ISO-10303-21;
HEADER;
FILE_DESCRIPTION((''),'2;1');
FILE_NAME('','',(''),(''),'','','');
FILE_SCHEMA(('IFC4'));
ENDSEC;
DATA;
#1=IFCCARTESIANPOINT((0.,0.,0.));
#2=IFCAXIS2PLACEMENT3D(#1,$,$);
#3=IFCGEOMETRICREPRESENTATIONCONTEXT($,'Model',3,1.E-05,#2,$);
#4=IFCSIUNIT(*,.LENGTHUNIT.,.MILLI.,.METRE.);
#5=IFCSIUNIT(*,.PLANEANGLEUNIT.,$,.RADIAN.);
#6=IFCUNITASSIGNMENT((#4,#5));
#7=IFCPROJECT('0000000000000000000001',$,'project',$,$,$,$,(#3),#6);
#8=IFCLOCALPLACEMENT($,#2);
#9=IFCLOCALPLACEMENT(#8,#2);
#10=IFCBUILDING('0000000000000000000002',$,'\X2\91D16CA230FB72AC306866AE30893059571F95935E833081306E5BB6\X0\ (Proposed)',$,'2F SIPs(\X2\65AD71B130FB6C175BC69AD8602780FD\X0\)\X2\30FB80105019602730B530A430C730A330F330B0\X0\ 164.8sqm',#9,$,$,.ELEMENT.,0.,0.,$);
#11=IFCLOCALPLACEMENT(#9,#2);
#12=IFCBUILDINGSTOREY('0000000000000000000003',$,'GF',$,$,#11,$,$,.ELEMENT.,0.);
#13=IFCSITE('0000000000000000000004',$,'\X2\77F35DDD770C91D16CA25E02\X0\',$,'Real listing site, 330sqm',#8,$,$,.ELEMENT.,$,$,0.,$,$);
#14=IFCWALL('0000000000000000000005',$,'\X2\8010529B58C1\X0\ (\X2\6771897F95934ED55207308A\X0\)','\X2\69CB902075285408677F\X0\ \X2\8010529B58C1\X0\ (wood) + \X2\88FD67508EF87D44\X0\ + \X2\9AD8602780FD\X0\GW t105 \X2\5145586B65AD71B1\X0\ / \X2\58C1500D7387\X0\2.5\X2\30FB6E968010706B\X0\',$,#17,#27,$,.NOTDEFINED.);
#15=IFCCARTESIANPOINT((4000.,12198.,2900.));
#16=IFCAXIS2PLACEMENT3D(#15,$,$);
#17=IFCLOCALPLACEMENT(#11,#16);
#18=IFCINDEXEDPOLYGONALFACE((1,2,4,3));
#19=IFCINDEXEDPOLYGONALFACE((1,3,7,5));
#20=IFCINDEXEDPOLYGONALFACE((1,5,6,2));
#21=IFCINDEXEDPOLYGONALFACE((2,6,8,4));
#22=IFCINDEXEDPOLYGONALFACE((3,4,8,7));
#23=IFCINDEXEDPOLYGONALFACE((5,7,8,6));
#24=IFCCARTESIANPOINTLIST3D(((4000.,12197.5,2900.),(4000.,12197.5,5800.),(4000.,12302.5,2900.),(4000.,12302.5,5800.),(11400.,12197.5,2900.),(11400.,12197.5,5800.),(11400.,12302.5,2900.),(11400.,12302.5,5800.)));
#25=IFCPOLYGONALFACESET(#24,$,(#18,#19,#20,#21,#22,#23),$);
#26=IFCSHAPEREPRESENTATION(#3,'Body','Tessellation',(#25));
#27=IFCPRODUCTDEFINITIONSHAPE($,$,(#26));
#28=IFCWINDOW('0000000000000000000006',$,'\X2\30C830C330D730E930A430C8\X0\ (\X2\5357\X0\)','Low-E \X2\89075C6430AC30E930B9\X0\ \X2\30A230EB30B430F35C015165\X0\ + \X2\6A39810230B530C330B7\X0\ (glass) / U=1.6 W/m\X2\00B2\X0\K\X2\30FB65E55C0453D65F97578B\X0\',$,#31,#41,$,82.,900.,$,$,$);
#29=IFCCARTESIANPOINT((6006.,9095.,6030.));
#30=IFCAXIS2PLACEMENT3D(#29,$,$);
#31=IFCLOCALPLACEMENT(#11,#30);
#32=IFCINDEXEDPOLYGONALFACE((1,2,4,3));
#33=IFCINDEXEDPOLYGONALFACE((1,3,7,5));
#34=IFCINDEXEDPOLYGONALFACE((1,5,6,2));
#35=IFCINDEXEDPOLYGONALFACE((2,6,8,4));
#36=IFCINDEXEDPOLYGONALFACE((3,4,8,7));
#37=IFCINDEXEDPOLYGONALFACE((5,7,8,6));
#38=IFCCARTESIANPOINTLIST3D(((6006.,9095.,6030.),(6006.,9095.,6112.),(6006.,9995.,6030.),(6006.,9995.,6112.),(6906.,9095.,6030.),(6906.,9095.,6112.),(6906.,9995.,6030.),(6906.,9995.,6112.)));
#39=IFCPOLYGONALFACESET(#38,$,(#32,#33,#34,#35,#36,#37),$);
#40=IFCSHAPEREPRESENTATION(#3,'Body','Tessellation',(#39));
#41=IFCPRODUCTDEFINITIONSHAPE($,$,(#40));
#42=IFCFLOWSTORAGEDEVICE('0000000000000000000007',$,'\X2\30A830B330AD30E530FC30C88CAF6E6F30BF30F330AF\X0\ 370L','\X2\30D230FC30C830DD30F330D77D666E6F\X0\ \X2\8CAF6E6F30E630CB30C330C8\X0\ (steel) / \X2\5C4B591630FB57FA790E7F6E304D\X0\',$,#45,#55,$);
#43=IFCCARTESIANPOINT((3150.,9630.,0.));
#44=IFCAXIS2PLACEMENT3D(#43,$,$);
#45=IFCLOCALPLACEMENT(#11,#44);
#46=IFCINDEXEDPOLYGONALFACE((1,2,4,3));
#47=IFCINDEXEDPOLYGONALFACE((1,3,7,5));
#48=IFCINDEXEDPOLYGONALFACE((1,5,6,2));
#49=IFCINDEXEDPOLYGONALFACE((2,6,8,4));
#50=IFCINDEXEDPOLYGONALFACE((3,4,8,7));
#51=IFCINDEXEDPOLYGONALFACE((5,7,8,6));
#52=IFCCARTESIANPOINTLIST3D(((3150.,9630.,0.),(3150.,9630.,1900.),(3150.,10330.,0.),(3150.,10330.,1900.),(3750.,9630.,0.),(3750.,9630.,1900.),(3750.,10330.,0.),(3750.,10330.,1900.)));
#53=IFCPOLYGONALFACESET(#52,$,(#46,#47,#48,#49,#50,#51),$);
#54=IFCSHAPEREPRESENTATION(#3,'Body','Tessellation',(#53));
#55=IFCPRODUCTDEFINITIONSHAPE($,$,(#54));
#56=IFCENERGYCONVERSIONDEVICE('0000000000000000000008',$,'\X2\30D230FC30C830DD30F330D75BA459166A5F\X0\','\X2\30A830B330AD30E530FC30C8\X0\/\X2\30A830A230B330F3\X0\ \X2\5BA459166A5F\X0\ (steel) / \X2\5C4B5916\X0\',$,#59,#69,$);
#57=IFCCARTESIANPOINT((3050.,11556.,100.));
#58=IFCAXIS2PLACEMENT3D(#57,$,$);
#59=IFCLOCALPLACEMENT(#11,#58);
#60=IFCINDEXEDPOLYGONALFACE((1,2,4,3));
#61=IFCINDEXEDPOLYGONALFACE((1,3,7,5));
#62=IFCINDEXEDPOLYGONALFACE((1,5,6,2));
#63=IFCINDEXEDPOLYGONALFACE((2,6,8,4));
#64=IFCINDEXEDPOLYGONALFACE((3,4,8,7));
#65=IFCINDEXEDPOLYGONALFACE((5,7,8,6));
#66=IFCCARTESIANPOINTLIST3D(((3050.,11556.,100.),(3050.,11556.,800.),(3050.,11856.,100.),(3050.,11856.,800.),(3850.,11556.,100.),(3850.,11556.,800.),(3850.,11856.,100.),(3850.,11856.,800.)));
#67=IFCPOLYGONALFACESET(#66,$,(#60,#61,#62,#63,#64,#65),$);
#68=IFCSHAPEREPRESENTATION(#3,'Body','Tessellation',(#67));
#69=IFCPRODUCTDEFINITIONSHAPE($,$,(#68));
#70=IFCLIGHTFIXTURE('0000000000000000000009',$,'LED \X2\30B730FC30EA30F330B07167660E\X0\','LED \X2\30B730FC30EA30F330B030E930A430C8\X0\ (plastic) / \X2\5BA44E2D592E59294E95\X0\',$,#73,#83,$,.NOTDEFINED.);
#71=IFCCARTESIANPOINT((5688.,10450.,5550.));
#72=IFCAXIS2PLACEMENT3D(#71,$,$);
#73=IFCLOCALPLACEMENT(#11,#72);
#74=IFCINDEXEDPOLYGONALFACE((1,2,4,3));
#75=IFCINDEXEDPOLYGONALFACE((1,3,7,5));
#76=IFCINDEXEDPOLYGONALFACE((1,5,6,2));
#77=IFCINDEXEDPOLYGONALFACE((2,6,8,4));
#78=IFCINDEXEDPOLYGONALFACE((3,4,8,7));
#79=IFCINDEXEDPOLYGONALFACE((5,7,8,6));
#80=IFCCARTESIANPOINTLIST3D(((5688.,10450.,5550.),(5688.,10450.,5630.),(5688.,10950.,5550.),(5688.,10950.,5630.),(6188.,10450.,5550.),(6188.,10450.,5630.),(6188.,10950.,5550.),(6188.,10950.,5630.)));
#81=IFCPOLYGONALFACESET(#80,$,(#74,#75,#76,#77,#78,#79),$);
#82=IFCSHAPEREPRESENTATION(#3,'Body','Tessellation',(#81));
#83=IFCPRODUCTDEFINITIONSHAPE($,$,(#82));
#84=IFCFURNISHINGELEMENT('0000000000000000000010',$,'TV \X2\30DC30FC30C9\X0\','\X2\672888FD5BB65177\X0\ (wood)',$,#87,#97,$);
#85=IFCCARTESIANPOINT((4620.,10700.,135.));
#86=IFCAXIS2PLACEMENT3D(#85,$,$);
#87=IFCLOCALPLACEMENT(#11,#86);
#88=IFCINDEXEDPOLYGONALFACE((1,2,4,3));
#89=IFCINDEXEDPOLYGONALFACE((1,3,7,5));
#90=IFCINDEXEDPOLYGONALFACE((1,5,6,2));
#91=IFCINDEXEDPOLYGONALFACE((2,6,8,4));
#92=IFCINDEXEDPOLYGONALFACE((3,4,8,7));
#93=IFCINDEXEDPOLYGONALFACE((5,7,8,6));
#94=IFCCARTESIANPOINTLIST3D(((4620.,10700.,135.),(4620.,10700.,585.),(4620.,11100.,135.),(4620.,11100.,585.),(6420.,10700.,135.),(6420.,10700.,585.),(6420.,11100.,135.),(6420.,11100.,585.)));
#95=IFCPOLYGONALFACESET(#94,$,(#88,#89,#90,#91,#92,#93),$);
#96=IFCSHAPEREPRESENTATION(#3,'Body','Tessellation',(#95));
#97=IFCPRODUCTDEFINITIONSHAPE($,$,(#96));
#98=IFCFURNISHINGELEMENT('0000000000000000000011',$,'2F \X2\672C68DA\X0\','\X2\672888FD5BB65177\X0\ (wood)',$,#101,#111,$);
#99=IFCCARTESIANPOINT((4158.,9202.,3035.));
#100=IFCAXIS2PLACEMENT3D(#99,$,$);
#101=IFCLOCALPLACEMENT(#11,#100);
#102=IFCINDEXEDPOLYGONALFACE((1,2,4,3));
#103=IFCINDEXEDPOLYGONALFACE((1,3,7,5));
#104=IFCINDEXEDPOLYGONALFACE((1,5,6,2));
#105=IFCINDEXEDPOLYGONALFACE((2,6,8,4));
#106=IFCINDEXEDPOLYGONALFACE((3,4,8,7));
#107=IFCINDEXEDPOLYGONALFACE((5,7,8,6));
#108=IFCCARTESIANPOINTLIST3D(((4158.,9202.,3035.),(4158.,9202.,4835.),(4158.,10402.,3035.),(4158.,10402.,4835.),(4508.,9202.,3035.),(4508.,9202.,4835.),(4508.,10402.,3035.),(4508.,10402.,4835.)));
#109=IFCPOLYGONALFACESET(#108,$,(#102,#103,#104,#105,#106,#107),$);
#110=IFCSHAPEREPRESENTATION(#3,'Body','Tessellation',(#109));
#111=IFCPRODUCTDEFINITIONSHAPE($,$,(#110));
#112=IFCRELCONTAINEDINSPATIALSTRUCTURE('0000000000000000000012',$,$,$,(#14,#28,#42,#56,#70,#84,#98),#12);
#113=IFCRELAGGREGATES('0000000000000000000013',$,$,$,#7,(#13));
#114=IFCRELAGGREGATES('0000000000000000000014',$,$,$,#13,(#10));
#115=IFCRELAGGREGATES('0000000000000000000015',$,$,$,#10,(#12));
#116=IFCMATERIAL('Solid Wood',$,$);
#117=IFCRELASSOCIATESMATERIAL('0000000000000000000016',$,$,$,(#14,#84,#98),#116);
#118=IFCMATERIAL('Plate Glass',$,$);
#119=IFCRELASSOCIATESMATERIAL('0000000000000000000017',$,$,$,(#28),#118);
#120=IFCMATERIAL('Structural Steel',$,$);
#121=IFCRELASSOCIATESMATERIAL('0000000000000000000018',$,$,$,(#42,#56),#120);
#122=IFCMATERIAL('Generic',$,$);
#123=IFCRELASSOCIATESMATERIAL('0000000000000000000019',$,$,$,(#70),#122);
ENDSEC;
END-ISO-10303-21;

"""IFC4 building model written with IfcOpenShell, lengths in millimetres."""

from ifc_helpers import new_model, si_unit, frame, frame_2d, origin, place, context, project, spatial, rectangle, extrude, material, element, save


model = new_model("IFC4")

# Units and contexts
model_context = context("Model", 3, precision=1e-05, world=origin())
ifc_project = project(units=[si_unit("LENGTHUNIT", "METRE", prefix="MILLI"), si_unit("PLANEANGLEUNIT", "RADIAN")], contexts=[model_context])

# Site, building, storey
site_placement = place(None, origin())
site = spatial("IfcSite", under=ifc_project, at=site_placement, Name="石川県金沢市", ObjectType="Real listing site, 330sqm", CompositionType="ELEMENT", RefElevation=0.0)
building_placement = place(site_placement, origin())
building = spatial("IfcBuilding", under=site, at=building_placement, Name="金沢・犬と暮らす土間広めの家 (Proposed)", ObjectType="2F SIPs(断熱・気密高性能)・耐候性サイディング 164.8sqm", CompositionType="ELEMENT", ElevationOfRefHeight=0.0, ElevationOfTerrain=0.0)
storey_placement = place(building_placement, origin())
storey = spatial("IfcBuildingStorey", under=building, at=storey_placement, Name="GF", CompositionType="ELEMENT", Elevation=0.0)

# Shared definitions
ifc_material_1 = material(Name="Solid Wood")

# Wall
wall_1_placement = place(storey_placement, frame((4000.0, 12198.0, 2900.0)))
element("IfcWall", 1, at=wall_1_placement, inside=storey, material=ifc_material_1, Name="耐力壁 (東西間仕切り)", Description="構造用合板 耐力壁 (wood) + 製材軸組 + 高性能GW t105 充填断熱 / 壁倍率2.5・準耐火", PredefinedType="NOTDEFINED", context=model_context, shape_type="SweptSolid", body=[
    extrude(rectangle(XDim=7400.0, YDim=105.0, at=frame_2d((3700.0, 52.0))), frame((4000.0, 12198.0, 2900.0)), (0.0, 0.0, 1.0), 2900.0),
])

# Window
ifc_material_2 = material(Name="Plate Glass")
window_placement = place(storey_placement, frame((6006.0, 9095.0, 6030.0)))
element("IfcWindow", 2, at=window_placement, inside=storey, material=ifc_material_2, Name="トップライト (南)", Description="Low-E 複層ガラス アルゴン封入 + 樹脂サッシ (glass) / U=1.6 W/m²K・日射取得型", OverallHeight=82.0, OverallWidth=900.0, context=model_context, shape_type="SweptSolid", body=[
    extrude(rectangle(XDim=900.0, YDim=900.0, at=frame_2d((450.0, 450.0))), frame((6006.0, 9095.0, 6030.0)), (0.0, 0.0, 1.0), 82.0),
])

# Flow storage device
ifc_material_3 = material(Name="Structural Steel")
flow_storage_device_placement = place(storey_placement, frame((3150.0, 9630.0, 0.0)))
element("IfcFlowStorageDevice", 3, at=flow_storage_device_placement, inside=storey, material=ifc_material_3, Name="エコキュート貯湯タンク 370L", Description="ヒートポンプ給湯 貯湯ユニット (steel) / 屋外・基礎置き", context=model_context, shape_type="SweptSolid", body=[
    extrude(rectangle(XDim=600.0, YDim=700.0, at=frame_2d((300.0, 350.0))), frame((3150.0, 9630.0, 0.0)), (0.0, 0.0, 1.0), 1900.0),
])

# Energy conversion device
energy_conversion_device_placement = place(storey_placement, frame((3050.0, 11556.0, 100.0)))
element("IfcEnergyConversionDevice", 4, at=energy_conversion_device_placement, inside=storey, material=ifc_material_3, Name="ヒートポンプ室外機", Description="エコキュート/エアコン 室外機 (steel) / 屋外", context=model_context, shape_type="SweptSolid", body=[
    extrude(rectangle(XDim=800.0, YDim=300.0, at=frame_2d((400.0, 150.0))), frame((3050.0, 11556.0, 100.0)), (0.0, 0.0, 1.0), 700.0),
])

# Light fixture
ifc_material_4 = material(Name="Generic")
light_fixture_placement = place(storey_placement, frame((5688.0, 10450.0, 5550.0)))
element("IfcLightFixture", 5, at=light_fixture_placement, inside=storey, material=ifc_material_4, Name="LED シーリング照明", Description="LED シーリングライト (plastic) / 室中央天井", PredefinedType="NOTDEFINED", context=model_context, shape_type="SweptSolid", body=[
    extrude(rectangle(XDim=500.0, YDim=500.0, at=frame_2d((250.0, 250.0))), frame((5688.0, 10450.0, 5550.0)), (0.0, 0.0, 1.0), 80.0),
])

# Furnishing elements
furnishing_1_placement = place(storey_placement, frame((4620.0, 10700.0, 135.0)))
element("IfcFurnishingElement", 6, at=furnishing_1_placement, inside=storey, material=ifc_material_1, Name="TV ボード", Description="木製家具 (wood)", context=model_context, shape_type="SweptSolid", body=[
    extrude(rectangle(XDim=1800.0, YDim=400.0, at=frame_2d((900.0, 200.0))), frame((4620.0, 10700.0, 135.0)), (0.0, 0.0, 1.0), 450.0),
])
furnishing_2_placement = place(storey_placement, frame((4158.0, 9202.0, 3035.0)))
element("IfcFurnishingElement", 7, at=furnishing_2_placement, inside=storey, material=ifc_material_1, Name="2F 本棚", Description="木製家具 (wood)", context=model_context, shape_type="SweptSolid", body=[
    extrude(rectangle(XDim=350.0, YDim=1200.0, at=frame_2d((175.0, 600.0))), frame((4158.0, 9202.0, 3035.0)), (0.0, 0.0, 1.0), 1800.0),
])

save(model, "model.ifc")
